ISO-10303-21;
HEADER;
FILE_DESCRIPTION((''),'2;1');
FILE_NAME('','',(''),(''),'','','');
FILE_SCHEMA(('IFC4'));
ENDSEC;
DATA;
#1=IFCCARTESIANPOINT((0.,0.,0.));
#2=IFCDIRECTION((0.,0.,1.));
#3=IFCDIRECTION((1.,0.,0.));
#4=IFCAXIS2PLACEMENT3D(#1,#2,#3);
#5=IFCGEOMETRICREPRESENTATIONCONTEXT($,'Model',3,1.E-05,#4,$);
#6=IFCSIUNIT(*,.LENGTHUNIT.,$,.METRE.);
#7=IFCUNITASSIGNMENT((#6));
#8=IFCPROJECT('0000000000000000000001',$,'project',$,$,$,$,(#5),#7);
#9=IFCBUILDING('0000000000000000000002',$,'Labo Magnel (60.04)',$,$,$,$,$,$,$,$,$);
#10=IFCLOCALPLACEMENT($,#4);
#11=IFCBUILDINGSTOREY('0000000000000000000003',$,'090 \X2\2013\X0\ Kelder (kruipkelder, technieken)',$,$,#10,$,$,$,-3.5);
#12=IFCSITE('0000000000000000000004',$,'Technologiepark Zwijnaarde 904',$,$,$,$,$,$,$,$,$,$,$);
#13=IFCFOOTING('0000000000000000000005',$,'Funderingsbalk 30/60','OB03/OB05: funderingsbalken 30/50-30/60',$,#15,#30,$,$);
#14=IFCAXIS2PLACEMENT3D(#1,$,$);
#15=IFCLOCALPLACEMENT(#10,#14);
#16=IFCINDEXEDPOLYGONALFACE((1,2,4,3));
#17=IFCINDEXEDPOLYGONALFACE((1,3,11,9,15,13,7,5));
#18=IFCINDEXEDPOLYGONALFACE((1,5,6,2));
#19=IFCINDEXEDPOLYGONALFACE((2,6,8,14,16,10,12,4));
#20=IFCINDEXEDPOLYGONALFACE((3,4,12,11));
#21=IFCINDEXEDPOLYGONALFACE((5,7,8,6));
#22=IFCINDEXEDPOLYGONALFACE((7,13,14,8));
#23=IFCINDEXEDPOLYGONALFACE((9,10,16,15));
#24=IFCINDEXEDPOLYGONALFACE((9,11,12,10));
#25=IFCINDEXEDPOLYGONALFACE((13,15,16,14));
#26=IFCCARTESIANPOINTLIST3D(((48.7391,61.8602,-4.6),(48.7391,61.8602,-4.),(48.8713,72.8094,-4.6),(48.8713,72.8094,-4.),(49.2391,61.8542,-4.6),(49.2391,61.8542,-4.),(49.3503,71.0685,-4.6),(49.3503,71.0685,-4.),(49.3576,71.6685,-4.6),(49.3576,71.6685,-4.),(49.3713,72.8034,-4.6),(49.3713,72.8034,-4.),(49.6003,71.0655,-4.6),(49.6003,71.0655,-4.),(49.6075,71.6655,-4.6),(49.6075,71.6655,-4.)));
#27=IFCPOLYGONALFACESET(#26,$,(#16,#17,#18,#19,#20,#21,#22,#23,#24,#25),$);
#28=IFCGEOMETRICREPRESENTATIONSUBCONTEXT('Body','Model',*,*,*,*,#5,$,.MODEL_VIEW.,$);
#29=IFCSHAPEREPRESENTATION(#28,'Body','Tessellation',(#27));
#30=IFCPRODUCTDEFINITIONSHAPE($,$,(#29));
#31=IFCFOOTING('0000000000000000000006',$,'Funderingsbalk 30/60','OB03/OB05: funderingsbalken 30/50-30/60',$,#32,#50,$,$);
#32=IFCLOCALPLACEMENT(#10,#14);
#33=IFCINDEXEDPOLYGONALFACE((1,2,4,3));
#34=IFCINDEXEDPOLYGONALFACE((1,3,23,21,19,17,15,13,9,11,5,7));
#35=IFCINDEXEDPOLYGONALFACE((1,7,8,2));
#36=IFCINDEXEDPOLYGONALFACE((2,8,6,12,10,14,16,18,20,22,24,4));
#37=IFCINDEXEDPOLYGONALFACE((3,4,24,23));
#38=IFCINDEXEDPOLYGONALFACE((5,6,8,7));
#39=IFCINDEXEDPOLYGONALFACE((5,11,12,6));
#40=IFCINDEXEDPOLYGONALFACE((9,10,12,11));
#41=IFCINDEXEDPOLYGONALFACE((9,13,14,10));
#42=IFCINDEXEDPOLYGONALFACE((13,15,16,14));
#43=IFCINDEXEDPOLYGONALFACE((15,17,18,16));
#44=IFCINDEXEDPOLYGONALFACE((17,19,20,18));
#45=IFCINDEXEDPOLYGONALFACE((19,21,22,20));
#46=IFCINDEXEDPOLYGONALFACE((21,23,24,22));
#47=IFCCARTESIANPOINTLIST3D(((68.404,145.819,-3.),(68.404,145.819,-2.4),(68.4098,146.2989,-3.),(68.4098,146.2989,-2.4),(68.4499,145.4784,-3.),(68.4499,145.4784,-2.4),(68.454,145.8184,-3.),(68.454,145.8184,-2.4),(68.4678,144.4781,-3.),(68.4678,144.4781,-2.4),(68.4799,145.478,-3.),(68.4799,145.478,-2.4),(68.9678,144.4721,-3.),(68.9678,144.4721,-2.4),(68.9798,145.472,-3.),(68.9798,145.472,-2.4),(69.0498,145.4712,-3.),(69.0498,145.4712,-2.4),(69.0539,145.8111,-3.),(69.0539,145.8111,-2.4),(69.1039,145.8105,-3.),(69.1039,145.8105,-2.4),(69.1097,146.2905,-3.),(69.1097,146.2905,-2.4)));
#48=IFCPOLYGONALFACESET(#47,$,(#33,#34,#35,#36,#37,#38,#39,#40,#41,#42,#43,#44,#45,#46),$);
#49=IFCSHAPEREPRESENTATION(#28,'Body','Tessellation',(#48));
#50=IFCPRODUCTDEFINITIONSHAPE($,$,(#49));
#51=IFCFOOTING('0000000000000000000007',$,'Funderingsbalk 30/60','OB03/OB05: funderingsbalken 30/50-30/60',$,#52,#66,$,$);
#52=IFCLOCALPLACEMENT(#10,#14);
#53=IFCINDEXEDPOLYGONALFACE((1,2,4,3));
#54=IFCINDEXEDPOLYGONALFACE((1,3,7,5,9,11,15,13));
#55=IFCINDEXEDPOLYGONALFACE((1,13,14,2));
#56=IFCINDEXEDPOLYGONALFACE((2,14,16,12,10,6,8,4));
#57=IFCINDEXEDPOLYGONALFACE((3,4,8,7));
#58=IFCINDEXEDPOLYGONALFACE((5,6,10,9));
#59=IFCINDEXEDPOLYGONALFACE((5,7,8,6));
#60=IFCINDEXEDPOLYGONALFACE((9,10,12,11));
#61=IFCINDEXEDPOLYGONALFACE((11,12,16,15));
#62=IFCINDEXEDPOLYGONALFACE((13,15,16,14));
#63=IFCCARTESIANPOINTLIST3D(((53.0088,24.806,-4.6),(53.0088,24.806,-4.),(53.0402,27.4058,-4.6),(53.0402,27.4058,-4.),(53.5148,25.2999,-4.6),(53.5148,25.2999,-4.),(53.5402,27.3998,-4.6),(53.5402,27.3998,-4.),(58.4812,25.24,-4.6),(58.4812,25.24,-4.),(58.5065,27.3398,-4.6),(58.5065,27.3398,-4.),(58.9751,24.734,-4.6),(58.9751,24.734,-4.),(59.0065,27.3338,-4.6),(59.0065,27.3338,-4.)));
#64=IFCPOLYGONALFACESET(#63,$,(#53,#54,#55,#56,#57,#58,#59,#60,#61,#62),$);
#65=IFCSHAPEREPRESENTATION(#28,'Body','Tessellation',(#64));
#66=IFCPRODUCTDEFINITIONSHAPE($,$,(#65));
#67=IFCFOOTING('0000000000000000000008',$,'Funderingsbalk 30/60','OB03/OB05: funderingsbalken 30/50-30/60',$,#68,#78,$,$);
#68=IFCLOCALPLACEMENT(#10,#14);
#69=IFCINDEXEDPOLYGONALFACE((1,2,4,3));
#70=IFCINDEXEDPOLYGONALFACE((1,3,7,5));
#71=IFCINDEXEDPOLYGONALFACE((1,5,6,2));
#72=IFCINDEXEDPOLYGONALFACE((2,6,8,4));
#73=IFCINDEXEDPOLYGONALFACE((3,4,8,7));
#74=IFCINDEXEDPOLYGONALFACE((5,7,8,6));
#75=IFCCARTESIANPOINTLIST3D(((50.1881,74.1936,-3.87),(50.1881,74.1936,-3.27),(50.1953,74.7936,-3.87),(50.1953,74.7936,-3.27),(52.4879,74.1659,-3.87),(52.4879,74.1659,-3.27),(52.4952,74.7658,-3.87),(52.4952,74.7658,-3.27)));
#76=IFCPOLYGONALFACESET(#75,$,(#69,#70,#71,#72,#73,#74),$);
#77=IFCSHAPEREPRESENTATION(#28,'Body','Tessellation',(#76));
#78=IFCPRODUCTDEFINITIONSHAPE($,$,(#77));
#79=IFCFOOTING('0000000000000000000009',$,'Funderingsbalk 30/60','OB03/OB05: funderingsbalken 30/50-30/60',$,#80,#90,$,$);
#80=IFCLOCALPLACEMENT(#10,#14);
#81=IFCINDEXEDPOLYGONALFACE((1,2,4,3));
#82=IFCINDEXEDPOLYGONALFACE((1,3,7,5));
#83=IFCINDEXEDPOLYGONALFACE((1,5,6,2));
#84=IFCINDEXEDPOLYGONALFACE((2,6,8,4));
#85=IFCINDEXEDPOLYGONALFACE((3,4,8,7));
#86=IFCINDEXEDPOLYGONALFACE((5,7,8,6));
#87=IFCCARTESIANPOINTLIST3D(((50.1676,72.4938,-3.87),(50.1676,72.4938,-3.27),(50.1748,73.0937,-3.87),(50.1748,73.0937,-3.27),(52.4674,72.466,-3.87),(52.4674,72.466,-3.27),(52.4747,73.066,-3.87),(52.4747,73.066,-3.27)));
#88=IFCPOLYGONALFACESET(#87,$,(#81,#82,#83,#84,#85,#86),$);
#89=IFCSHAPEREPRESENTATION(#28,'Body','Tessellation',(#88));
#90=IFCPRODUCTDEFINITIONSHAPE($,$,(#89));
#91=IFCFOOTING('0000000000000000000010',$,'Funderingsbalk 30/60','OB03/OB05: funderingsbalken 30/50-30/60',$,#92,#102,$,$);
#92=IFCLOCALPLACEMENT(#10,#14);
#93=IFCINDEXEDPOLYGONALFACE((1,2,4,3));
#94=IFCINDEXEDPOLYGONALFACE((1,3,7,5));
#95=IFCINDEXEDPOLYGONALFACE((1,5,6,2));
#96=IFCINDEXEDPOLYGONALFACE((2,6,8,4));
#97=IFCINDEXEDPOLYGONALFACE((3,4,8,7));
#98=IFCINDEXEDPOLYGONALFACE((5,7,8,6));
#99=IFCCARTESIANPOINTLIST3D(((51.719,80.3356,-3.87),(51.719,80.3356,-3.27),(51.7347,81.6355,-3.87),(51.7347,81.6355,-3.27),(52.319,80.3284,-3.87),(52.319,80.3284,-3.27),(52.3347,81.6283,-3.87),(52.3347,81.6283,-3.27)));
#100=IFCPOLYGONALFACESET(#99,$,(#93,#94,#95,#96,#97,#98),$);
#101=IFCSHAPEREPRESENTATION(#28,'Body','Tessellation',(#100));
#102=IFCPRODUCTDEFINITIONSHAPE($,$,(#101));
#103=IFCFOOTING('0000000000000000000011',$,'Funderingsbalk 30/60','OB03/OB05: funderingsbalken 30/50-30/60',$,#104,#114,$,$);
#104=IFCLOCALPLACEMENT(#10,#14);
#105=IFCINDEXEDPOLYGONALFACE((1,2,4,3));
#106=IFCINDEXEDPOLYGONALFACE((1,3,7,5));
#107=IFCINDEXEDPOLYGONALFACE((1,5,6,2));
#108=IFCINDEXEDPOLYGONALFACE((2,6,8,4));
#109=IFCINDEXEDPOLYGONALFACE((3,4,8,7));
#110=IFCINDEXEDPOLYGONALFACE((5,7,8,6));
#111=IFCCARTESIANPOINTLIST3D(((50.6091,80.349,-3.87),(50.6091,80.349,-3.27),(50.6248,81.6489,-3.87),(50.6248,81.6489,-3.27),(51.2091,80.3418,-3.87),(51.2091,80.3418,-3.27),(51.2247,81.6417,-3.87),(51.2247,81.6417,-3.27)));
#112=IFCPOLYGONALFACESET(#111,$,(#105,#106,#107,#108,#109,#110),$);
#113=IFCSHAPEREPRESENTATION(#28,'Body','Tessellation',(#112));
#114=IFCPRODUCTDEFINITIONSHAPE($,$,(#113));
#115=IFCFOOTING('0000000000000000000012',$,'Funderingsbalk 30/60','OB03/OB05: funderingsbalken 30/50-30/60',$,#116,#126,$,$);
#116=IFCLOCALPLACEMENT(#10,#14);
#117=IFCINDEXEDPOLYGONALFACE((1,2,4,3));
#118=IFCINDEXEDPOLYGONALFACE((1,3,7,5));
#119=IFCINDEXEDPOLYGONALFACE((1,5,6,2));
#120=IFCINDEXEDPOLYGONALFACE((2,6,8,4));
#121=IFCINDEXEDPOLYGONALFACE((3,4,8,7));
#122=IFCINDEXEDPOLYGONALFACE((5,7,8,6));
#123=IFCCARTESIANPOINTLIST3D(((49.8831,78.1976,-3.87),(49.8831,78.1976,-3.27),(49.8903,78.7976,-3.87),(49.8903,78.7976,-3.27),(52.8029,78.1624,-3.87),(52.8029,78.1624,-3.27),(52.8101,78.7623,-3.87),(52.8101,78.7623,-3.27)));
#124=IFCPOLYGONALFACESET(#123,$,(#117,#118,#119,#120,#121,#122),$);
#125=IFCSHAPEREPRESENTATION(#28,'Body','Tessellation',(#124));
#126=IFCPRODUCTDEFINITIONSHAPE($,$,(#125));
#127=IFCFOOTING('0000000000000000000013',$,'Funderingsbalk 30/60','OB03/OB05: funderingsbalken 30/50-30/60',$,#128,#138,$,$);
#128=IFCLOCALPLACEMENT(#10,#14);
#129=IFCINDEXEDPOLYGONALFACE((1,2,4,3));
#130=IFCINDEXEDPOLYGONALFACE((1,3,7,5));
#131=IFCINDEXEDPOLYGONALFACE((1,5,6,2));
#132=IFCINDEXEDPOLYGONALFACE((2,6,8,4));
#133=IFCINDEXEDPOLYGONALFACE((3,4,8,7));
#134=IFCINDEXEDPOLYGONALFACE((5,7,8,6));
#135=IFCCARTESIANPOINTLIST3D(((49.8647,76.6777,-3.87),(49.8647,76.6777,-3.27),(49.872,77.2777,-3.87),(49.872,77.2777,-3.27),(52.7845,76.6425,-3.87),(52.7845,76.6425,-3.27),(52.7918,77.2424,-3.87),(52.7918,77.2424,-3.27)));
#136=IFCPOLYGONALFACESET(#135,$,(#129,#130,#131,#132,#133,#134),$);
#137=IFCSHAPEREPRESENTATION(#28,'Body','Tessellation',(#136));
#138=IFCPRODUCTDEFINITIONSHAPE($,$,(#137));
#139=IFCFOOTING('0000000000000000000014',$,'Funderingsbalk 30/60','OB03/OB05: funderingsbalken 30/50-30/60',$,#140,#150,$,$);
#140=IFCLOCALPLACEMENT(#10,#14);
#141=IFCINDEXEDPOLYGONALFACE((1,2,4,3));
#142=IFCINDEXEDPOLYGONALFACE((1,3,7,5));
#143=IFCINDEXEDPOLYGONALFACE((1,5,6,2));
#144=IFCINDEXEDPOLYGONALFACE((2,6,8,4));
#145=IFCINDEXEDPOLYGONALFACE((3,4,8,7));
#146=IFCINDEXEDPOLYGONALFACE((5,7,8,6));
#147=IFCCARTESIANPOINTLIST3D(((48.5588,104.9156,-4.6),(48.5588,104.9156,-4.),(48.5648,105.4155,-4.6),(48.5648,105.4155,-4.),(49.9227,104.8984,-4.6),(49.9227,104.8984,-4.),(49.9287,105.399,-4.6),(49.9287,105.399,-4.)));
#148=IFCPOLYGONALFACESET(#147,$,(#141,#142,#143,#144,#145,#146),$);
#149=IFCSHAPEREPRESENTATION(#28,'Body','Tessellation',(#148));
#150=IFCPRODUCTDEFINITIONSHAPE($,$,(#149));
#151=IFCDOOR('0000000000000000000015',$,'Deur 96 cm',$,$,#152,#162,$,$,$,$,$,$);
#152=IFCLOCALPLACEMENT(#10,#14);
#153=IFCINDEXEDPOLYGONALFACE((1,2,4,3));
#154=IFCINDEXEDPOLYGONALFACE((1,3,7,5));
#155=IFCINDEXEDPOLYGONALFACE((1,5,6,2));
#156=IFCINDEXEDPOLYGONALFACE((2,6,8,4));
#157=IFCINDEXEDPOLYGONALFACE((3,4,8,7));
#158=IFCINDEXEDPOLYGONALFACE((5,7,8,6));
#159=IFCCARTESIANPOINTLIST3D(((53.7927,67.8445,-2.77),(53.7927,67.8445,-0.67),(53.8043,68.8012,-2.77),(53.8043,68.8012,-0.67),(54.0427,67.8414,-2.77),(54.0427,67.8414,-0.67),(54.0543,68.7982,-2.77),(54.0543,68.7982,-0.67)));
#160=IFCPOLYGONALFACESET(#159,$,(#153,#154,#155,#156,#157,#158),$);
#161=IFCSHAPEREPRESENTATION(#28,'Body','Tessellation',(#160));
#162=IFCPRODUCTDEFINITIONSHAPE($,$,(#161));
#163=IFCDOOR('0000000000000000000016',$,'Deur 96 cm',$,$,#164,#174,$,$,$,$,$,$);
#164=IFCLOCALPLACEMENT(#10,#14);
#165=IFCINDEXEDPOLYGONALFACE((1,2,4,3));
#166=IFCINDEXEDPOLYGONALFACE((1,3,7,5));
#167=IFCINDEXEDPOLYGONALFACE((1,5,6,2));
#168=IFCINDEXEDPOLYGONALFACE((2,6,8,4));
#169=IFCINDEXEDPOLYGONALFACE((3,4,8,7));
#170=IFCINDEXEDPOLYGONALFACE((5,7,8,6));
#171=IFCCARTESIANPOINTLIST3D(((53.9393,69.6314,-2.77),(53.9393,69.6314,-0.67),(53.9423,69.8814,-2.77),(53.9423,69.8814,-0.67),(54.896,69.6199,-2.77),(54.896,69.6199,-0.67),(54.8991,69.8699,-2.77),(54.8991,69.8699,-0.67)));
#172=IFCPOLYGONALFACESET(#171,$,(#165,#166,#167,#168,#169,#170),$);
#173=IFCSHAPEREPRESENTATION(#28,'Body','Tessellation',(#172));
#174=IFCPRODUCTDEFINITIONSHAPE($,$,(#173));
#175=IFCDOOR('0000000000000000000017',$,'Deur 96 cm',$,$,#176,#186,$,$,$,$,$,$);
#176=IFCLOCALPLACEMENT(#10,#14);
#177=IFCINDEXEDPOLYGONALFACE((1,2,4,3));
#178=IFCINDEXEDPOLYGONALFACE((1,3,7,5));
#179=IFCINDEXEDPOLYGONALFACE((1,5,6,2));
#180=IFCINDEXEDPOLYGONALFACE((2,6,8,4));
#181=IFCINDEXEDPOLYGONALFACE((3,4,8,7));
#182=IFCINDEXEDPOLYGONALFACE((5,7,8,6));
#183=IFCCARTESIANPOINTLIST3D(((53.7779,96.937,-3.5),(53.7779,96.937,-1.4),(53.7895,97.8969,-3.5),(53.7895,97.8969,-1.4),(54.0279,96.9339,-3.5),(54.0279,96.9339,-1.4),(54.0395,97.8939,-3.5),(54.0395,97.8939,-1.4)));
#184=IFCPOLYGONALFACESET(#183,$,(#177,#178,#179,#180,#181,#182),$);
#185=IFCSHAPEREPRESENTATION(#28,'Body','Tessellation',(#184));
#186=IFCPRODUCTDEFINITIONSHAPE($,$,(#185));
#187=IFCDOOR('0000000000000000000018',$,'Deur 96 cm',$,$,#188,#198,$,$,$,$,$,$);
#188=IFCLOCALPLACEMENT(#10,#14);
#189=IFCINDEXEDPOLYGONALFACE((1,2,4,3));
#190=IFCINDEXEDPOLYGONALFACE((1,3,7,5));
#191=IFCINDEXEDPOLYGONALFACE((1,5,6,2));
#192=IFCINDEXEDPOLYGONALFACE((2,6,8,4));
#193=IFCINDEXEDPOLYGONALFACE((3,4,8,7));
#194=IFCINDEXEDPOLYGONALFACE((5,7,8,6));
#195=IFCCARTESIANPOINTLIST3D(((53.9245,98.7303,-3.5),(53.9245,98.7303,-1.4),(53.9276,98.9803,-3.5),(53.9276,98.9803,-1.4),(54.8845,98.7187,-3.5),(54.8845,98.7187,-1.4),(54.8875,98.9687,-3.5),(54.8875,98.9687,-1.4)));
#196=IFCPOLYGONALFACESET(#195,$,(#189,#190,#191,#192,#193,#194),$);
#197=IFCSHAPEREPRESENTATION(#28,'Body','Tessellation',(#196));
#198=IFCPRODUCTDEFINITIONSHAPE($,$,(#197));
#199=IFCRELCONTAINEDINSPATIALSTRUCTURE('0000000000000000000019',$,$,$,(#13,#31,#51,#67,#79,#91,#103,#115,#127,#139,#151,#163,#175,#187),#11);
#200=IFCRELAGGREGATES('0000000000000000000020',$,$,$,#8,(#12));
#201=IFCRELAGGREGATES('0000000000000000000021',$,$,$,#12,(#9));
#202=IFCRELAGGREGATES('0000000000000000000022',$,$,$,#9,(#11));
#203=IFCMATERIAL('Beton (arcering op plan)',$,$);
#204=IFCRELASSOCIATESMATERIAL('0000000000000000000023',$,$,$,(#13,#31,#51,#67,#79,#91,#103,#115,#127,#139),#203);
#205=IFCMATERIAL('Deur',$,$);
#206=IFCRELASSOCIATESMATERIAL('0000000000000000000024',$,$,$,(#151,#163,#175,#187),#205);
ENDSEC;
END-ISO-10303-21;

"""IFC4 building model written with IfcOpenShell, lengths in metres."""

from ifc_helpers import new_model, si_unit, frame, origin, origin_with_axes, place, context, subcontext, project, spatial, polyline, outline, extrude, material, element, save


model = new_model("IFC4")

# Units and contexts
model_context = context("Model", 3, precision=1e-05, world=origin_with_axes())
body_context = subcontext(model_context, "Body", "Model", "MODEL_VIEW")
ifc_project = project(units=[si_unit("LENGTHUNIT", "METRE")], contexts=[model_context])

# Site, building, storey
site = spatial("IfcSite", under=ifc_project, Name="Technologiepark Zwijnaarde 904")
building = spatial("IfcBuilding", under=site, Name="Labo Magnel (60.04)")
storey_placement = place(None, origin_with_axes())
storey = spatial("IfcBuildingStorey", under=building, at=storey_placement, Name="090 – Kelder (kruipkelder, technieken)", Elevation=-3.5)

# Footings
ifc_material_1 = material(Name="Beton (arcering op plan)")
footing_1_placement = place(storey_placement, frame((0.0, 0.0, -4.6), z_axis=(0.0, 0.0, 1.0), x_axis=(1.0, 0.0, 0.0)))
element("IfcFooting", 1, at=footing_1_placement, inside=storey, material=ifc_material_1, Name="Funderingsbalk 30/60", Description="OB03/OB05: funderingsbalken 30/50-30/60", context=body_context, shape_type="SweptSolid", body=[
    extrude(outline(polyline([(49.3503, 71.0685), (49.2391, 61.8542), (48.7391, 61.8602), (48.8713, 72.8094), (49.3713, 72.8034), (49.3576, 71.6685), (49.6075, 71.6655), (49.6003, 71.0655), (49.3503, 71.0685)])), origin(), (0.0, 0.0, 1.0), 0.6),
])
footing_2_placement = place(storey_placement, frame((0.0, 0.0, -3.0), z_axis=(0.0, 0.0, 1.0), x_axis=(1.0, 0.0, 0.0)))
element("IfcFooting", 2, at=footing_2_placement, inside=storey, material=ifc_material_1, Name="Funderingsbalk 30/60", Description="OB03/OB05: funderingsbalken 30/50-30/60", context=body_context, shape_type="SweptSolid", body=[
    extrude(outline(polyline([(68.454, 145.8184), (68.404, 145.819), (68.4098, 146.2989), (69.1097, 146.2905), (69.1039, 145.8105), (69.0539, 145.8111), (69.0498, 145.4712), (68.9798, 145.472), (68.9678, 144.4721), (68.4678, 144.4781), (68.4799, 145.478), (68.4499, 145.4784), (68.454, 145.8184)])), origin(), (0.0, 0.0, 1.0), 0.6),
])
footing_3_placement = place(storey_placement, frame((0.0, 0.0, -4.6), z_axis=(0.0, 0.0, 1.0), x_axis=(1.0, 0.0, 0.0)))
element("IfcFooting", 3, at=footing_3_placement, inside=storey, material=ifc_material_1, Name="Funderingsbalk 30/60", Description="OB03/OB05: funderingsbalken 30/50-30/60", context=body_context, shape_type="SweptSolid", body=[
    extrude(outline(polyline([(59.0065, 27.3338), (58.9751, 24.734), (53.0088, 24.806), (53.0402, 27.4058), (53.5402, 27.3998), (53.5148, 25.2999), (58.4812, 25.24), (58.5065, 27.3398), (59.0065, 27.3338)])), origin(), (0.0, 0.0, 1.0), 0.6),
])
footing_4_placement = place(storey_placement, frame((0.0, 0.0, -3.87), z_axis=(0.0, 0.0, 1.0), x_axis=(1.0, 0.0, 0.0)))
element("IfcFooting", 4, at=footing_4_placement, inside=storey, material=ifc_material_1, Name="Funderingsbalk 30/60", Description="OB03/OB05: funderingsbalken 30/50-30/60", context=body_context, shape_type="SweptSolid", body=[
    extrude(outline(polyline([(52.4952, 74.7658), (52.4879, 74.1659), (50.1881, 74.1936), (50.1953, 74.7936), (52.4952, 74.7658)])), origin(), (0.0, 0.0, 1.0), 0.6),
])
footing_5_placement = place(storey_placement, frame((0.0, 0.0, -3.87), z_axis=(0.0, 0.0, 1.0), x_axis=(1.0, 0.0, 0.0)))
element("IfcFooting", 5, at=footing_5_placement, inside=storey, material=ifc_material_1, Name="Funderingsbalk 30/60", Description="OB03/OB05: funderingsbalken 30/50-30/60", context=body_context, shape_type="SweptSolid", body=[
    extrude(outline(polyline([(52.4747, 73.066), (52.4674, 72.466), (50.1676, 72.4938), (50.1748, 73.0937), (52.4747, 73.066)])), origin(), (0.0, 0.0, 1.0), 0.6),
])
footing_6_placement = place(storey_placement, frame((0.0, 0.0, -3.87), z_axis=(0.0, 0.0, 1.0), x_axis=(1.0, 0.0, 0.0)))
element("IfcFooting", 6, at=footing_6_placement, inside=storey, material=ifc_material_1, Name="Funderingsbalk 30/60", Description="OB03/OB05: funderingsbalken 30/50-30/60", context=body_context, shape_type="SweptSolid", body=[
    extrude(outline(polyline([(52.3347, 81.6283), (52.319, 80.3284), (51.719, 80.3356), (51.7347, 81.6355), (52.3347, 81.6283)])), origin(), (0.0, 0.0, 1.0), 0.6),
])
footing_7_placement = place(storey_placement, frame((0.0, 0.0, -3.87), z_axis=(0.0, 0.0, 1.0), x_axis=(1.0, 0.0, 0.0)))
element("IfcFooting", 7, at=footing_7_placement, inside=storey, material=ifc_material_1, Name="Funderingsbalk 30/60", Description="OB03/OB05: funderingsbalken 30/50-30/60", context=body_context, shape_type="SweptSolid", body=[
    extrude(outline(polyline([(51.2247, 81.6417), (51.2091, 80.3418), (50.6091, 80.349), (50.6248, 81.6489), (51.2247, 81.6417)])), origin(), (0.0, 0.0, 1.0), 0.6),
])
footing_8_placement = place(storey_placement, frame((0.0, 0.0, -3.87), z_axis=(0.0, 0.0, 1.0), x_axis=(1.0, 0.0, 0.0)))
element("IfcFooting", 8, at=footing_8_placement, inside=storey, material=ifc_material_1, Name="Funderingsbalk 30/60", Description="OB03/OB05: funderingsbalken 30/50-30/60", context=body_context, shape_type="SweptSolid", body=[
    extrude(outline(polyline([(52.8101, 78.7623), (52.8029, 78.1624), (49.8831, 78.1976), (49.8903, 78.7976), (52.8101, 78.7623)])), origin(), (0.0, 0.0, 1.0), 0.6),
])
footing_9_placement = place(storey_placement, frame((0.0, 0.0, -3.87), z_axis=(0.0, 0.0, 1.0), x_axis=(1.0, 0.0, 0.0)))
element("IfcFooting", 9, at=footing_9_placement, inside=storey, material=ifc_material_1, Name="Funderingsbalk 30/60", Description="OB03/OB05: funderingsbalken 30/50-30/60", context=body_context, shape_type="SweptSolid", body=[
    extrude(outline(polyline([(52.7918, 77.2424), (52.7845, 76.6425), (49.8647, 76.6777), (49.872, 77.2777), (52.7918, 77.2424)])), origin(), (0.0, 0.0, 1.0), 0.6),
])
footing_10_placement = place(storey_placement, frame((0.0, 0.0, -4.6), z_axis=(0.0, 0.0, 1.0), x_axis=(1.0, 0.0, 0.0)))
element("IfcFooting", 10, at=footing_10_placement, inside=storey, material=ifc_material_1, Name="Funderingsbalk 30/60", Description="OB03/OB05: funderingsbalken 30/50-30/60", context=body_context, shape_type="SweptSolid", body=[
    extrude(outline(polyline([(48.5648, 105.4155), (49.9287, 105.399), (49.9227, 104.8984), (48.5588, 104.9156), (48.5648, 105.4155)])), origin(), (0.0, 0.0, 1.0), 0.6),
])

# Doors
ifc_material_2 = material(Name="Deur")
for number, where, z_axis, x_axis, name in (
    (11, (53.9177, 67.843, -2.77), (0.0, 0.0, 1.0), (0.01207, 0.999927, 0.0), "Deur 96 cm"),
    (12, (53.9408, 69.7564, -2.77), (0.0, 0.0, 1.0), (0.999927, -0.01207, 0.0), "Deur 96 cm"),
):
    element("IfcDoor", number, at=place(storey_placement, frame(where, z_axis=z_axis, x_axis=x_axis)), inside=storey, material=ifc_material_2, Name=name, context=body_context, shape_type="SweptSolid", body=[
        extrude(outline(polyline([(0.0, -0.125), (0.9568, -0.125), (0.9568, 0.125), (0.0, 0.125), (0.0, -0.125)])), origin(), (0.0, 0.0, 1.0), 2.1),
    ])
for number, where, z_axis, x_axis, name in (
    (13, (53.9029, 96.9355, -3.5), (0.0, 0.0, 1.0), (0.01207, 0.999927, 0.0), "Deur 96 cm"),
    (14, (53.9261, 98.8553, -3.5), (0.0, 0.0, 1.0), (0.999927, -0.01207, 0.0), "Deur 96 cm"),
):
    element("IfcDoor", number, at=place(storey_placement, frame(where, z_axis=z_axis, x_axis=x_axis)), inside=storey, material=ifc_material_2, Name=name, context=body_context, shape_type="SweptSolid", body=[
        extrude(outline(polyline([(0.0, -0.125), (0.96, -0.125), (0.96, 0.125), (0.0, 0.125), (0.0, -0.125)])), origin(), (0.0, 0.0, 1.0), 2.1),
    ])

save(model, "model.ifc")
